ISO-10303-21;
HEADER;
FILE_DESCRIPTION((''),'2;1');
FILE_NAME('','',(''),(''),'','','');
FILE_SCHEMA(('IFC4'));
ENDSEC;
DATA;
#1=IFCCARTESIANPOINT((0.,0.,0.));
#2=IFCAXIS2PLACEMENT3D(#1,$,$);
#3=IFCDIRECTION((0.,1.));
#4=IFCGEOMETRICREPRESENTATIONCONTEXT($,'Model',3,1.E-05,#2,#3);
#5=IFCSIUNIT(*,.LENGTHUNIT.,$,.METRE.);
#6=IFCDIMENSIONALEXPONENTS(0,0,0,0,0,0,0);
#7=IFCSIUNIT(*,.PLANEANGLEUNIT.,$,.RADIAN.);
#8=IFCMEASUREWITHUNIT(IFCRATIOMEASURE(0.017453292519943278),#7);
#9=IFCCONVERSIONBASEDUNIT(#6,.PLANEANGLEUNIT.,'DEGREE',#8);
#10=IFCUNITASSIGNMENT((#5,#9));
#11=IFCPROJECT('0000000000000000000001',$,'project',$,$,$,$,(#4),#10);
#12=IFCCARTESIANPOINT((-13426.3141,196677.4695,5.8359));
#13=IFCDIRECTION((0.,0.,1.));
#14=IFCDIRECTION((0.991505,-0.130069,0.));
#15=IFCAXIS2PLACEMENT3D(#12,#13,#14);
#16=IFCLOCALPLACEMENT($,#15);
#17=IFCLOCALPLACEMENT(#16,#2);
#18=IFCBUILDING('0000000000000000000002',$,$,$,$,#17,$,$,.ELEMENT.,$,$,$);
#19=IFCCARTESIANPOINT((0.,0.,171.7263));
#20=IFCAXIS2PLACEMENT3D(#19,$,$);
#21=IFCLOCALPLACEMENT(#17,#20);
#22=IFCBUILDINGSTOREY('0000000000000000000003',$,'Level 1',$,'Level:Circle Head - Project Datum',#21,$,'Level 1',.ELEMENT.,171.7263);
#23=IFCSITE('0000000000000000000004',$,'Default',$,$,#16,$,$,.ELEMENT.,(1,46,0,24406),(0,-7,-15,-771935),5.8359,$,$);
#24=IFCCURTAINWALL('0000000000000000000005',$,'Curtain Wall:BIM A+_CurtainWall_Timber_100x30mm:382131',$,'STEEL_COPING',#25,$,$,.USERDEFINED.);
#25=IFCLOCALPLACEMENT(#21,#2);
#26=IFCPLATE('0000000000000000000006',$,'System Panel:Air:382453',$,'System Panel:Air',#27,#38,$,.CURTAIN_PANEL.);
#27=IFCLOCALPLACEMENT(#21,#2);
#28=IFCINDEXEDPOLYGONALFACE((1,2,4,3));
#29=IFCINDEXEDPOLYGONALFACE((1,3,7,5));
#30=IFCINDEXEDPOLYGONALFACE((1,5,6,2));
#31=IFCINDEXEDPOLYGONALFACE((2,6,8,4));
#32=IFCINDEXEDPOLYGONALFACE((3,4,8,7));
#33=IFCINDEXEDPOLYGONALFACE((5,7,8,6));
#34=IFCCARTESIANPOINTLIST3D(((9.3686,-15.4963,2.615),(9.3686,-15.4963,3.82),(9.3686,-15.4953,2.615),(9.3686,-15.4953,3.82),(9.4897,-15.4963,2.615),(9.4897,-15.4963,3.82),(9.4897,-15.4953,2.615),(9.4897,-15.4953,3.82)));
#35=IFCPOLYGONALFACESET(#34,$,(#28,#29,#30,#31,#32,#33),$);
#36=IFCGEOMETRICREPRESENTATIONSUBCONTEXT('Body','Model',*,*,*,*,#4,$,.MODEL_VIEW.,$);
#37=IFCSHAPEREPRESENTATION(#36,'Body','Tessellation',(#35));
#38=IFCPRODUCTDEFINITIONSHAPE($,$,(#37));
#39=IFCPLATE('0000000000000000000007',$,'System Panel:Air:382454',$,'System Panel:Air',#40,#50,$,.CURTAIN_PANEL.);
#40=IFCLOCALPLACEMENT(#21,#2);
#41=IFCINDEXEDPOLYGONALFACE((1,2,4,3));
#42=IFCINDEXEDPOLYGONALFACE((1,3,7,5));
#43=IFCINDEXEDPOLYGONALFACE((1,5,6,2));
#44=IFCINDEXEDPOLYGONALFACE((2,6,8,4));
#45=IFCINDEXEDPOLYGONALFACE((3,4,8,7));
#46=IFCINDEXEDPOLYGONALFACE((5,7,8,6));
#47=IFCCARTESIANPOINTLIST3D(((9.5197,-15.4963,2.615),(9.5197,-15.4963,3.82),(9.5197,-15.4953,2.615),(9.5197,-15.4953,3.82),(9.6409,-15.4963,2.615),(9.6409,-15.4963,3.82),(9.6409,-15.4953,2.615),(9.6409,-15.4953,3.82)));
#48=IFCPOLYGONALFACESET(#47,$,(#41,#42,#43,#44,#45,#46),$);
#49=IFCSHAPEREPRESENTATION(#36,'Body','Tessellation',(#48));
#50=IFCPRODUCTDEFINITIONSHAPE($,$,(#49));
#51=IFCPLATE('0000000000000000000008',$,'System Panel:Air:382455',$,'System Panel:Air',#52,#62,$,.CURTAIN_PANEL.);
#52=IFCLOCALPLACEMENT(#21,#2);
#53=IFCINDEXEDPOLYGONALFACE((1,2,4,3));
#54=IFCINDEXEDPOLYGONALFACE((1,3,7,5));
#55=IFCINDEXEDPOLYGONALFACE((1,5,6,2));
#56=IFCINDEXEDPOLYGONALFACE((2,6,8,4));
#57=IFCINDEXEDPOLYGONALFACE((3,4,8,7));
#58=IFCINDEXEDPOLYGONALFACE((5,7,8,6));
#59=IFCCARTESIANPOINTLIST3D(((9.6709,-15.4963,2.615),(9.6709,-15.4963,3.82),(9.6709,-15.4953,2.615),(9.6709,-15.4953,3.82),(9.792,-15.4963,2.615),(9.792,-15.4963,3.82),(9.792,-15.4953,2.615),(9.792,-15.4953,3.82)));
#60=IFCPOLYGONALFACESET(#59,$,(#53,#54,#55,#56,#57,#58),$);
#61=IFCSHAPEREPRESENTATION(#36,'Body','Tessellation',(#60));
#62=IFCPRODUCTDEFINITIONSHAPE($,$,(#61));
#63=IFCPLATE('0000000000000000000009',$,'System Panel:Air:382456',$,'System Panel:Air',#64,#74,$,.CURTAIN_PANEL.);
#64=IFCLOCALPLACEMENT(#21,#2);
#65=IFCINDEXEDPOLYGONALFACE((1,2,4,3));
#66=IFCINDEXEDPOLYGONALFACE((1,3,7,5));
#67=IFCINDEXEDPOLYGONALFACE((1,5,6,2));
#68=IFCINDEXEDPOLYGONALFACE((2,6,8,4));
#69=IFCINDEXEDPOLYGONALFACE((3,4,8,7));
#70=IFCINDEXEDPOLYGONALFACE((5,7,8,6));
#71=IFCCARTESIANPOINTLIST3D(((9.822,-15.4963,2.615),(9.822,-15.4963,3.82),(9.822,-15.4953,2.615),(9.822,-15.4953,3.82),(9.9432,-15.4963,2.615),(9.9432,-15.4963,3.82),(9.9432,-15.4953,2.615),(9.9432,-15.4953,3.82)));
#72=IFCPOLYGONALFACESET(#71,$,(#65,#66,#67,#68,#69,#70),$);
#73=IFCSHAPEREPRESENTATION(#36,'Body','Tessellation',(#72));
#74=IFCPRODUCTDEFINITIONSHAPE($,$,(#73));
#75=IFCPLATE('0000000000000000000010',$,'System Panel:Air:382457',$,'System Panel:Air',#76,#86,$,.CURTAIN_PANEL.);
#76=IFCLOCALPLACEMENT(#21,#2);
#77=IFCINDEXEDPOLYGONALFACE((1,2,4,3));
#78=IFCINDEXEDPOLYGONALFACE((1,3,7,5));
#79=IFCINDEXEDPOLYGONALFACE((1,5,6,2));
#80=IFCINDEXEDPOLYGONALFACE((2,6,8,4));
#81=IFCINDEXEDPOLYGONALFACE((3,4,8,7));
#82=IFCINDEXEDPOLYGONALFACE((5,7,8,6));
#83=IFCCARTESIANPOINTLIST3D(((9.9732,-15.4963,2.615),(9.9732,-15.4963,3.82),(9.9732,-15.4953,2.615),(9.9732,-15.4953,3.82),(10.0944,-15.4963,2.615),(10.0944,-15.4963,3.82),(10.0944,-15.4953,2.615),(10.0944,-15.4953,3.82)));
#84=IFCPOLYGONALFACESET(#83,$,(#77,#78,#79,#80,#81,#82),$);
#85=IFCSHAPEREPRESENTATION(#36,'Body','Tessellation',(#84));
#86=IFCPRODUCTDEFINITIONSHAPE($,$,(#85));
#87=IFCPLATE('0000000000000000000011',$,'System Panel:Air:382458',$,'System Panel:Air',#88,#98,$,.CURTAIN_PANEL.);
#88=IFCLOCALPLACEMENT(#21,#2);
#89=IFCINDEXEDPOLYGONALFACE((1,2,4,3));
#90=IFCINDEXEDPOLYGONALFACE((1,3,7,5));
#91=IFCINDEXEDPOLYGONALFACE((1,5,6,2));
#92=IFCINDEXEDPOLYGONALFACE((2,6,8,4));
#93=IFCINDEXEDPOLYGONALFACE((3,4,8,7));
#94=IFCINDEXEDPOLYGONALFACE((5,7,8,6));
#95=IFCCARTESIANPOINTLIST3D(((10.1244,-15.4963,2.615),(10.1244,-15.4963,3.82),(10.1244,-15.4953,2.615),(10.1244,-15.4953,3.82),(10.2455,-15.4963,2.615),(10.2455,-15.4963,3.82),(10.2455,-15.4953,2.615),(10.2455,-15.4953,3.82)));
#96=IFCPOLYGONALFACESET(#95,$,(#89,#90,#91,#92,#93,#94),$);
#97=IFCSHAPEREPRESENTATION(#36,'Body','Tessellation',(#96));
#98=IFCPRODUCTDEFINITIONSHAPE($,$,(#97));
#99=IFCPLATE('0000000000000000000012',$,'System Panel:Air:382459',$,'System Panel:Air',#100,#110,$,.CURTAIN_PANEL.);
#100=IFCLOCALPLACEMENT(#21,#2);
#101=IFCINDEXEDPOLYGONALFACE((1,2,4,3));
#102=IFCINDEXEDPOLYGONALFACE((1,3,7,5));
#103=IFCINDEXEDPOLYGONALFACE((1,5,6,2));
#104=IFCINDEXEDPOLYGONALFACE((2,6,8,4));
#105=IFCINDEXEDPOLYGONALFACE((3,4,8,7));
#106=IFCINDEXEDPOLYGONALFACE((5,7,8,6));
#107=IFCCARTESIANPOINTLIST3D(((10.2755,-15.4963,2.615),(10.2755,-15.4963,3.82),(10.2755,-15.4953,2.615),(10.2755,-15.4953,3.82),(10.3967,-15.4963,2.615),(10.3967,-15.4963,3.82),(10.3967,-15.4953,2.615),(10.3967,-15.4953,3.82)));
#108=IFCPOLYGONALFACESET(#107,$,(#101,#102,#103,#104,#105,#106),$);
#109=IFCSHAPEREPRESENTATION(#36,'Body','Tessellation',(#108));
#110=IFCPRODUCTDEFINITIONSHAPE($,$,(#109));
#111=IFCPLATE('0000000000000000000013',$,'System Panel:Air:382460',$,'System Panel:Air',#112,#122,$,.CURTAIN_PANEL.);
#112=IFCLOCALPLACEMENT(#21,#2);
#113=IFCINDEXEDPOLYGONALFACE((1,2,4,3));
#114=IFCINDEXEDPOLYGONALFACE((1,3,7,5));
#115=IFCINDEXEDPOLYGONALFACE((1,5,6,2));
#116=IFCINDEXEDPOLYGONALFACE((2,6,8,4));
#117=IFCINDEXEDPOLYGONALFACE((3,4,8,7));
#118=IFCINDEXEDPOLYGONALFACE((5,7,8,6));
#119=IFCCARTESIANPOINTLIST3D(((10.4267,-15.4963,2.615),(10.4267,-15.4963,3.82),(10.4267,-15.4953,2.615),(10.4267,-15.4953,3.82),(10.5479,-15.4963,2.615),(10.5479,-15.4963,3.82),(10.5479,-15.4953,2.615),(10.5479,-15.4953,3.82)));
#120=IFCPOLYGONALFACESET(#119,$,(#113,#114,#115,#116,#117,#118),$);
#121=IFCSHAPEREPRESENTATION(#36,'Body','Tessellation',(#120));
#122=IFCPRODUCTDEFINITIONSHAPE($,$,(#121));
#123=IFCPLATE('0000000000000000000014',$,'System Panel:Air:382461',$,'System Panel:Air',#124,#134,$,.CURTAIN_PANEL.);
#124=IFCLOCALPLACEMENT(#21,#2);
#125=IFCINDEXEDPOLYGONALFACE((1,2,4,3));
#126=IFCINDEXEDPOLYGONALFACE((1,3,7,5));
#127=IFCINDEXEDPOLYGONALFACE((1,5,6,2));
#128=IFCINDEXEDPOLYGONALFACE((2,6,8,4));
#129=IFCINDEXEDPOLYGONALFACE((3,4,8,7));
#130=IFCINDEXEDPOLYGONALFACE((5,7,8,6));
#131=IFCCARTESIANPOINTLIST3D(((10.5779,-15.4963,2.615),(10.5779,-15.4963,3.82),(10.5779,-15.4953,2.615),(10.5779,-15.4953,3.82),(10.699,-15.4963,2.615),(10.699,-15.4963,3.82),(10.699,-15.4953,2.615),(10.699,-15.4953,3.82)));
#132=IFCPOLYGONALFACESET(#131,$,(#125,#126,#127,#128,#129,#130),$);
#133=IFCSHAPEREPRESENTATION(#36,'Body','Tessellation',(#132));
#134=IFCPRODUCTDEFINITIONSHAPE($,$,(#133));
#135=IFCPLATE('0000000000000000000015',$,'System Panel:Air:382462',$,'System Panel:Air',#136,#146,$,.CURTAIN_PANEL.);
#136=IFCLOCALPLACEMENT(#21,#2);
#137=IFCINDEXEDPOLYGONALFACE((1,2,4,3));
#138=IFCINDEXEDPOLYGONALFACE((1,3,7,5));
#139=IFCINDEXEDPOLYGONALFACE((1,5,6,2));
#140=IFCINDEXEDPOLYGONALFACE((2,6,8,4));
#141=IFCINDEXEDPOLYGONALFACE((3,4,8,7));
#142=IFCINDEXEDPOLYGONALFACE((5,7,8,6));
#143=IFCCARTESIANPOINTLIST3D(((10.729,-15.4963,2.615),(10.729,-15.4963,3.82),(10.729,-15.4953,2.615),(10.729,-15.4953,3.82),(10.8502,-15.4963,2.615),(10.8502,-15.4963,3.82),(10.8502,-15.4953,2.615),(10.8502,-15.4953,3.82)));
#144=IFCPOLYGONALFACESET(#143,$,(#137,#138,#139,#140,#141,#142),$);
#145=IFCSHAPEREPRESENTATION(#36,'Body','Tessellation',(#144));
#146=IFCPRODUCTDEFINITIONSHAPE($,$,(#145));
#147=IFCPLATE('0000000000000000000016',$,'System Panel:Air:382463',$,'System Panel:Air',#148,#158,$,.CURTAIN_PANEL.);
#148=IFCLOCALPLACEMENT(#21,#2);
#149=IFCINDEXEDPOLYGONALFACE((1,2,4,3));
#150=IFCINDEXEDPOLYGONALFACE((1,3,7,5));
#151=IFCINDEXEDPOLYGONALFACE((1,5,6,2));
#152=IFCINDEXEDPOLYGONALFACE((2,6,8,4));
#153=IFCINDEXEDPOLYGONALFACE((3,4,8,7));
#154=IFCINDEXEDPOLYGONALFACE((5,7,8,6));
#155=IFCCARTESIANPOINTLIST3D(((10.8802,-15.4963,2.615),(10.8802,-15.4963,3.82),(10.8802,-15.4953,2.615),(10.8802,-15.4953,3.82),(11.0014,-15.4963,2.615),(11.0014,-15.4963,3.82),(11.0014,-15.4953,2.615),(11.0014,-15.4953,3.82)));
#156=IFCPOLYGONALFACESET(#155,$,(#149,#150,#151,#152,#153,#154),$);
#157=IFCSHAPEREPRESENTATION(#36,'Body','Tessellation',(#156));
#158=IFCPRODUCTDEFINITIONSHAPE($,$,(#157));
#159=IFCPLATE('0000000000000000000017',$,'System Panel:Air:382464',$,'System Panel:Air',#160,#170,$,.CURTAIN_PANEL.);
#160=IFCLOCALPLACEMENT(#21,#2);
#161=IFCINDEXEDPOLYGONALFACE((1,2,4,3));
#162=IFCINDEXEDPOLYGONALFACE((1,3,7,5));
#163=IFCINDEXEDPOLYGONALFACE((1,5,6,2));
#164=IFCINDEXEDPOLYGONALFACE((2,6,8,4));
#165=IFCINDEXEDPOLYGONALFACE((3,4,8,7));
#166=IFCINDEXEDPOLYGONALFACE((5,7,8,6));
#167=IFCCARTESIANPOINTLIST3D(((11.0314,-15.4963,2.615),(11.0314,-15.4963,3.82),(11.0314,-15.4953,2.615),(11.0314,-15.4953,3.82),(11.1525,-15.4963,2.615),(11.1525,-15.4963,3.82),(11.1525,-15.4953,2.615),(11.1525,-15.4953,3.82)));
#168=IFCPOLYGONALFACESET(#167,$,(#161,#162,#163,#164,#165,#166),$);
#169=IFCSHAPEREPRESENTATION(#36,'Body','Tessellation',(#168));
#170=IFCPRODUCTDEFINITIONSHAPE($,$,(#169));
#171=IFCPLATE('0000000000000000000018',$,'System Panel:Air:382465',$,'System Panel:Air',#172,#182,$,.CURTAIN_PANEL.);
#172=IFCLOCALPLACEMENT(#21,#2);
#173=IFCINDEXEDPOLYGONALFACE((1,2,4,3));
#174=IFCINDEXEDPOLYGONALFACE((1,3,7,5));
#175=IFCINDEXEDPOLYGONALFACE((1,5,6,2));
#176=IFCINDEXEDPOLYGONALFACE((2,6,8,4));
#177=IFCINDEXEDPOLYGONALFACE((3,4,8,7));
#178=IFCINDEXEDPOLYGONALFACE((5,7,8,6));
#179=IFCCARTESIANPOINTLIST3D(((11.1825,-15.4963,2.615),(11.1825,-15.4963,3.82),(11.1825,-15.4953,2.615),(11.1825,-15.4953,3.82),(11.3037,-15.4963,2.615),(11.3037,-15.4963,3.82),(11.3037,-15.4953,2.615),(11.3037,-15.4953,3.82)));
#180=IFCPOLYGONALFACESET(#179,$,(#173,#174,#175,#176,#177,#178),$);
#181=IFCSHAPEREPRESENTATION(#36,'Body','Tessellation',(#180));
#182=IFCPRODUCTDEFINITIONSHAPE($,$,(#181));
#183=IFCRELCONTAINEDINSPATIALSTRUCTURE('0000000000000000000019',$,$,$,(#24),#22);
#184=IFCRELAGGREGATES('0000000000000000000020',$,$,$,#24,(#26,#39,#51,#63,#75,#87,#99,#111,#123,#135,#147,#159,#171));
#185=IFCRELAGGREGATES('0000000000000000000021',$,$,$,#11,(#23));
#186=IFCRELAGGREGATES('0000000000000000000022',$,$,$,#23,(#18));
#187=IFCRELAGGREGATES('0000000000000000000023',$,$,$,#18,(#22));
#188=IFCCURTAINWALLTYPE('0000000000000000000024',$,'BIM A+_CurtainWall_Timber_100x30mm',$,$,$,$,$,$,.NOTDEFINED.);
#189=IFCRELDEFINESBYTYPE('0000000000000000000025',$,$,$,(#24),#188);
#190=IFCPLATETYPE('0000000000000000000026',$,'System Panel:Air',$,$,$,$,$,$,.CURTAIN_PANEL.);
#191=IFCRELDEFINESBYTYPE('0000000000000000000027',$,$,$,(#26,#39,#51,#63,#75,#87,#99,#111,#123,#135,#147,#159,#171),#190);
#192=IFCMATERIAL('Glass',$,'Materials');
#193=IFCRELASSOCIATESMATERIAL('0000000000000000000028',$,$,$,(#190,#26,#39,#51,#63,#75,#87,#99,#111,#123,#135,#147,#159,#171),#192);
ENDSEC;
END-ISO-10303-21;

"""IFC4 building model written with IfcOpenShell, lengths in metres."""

from ifc_helpers import new_model, entity, si_unit, converted_unit, direction, frame, origin, place, context, subcontext, project, spatial, indexed_curve, outline, extrude, source, transform, mapped, material, type_object, type_shapes, element, aggregate, save


model = new_model("IFC4")

# Units and contexts
model_context = context("Model", 3, precision=1e-05, world=origin(), true_north=direction((0.0, 1.0)))
body_context = subcontext(model_context, "Body", "Model", "MODEL_VIEW")
ifc_project = project(units=[si_unit("LENGTHUNIT", "METRE"), converted_unit("PLANEANGLEUNIT", "DEGREE", entity("IfcRatioMeasure", 0.017453292519943278), si_unit("PLANEANGLEUNIT", "RADIAN"), dimensions=[0, 0, 0, 0, 0, 0, 0])], contexts=[model_context])

# Site, building, storey
site_placement = place(None, frame((-13426.3141, 196677.4695, 5.8359), z_axis=(0.0, 0.0, 1.0), x_axis=(0.991505, -0.130069, 0.0)))
site = spatial("IfcSite", under=ifc_project, at=site_placement, Name="Default", CompositionType="ELEMENT", RefLatitude=(1, 46, 0, 24406), RefLongitude=(0, -7, -15, -771935), RefElevation=5.8359)
building_placement = place(site_placement, origin())
building = spatial("IfcBuilding", under=site, at=building_placement, CompositionType="ELEMENT")
storey_placement = place(building_placement, frame((0.0, 0.0, 171.7263)))
storey = spatial("IfcBuildingStorey", under=building, at=storey_placement, Name="Level 1", ObjectType="Level:Circle Head - Project Datum", LongName="Level 1", CompositionType="ELEMENT", Elevation=171.7263)

# Curtain wall, plates
curtain_wall_type = type_object("IfcCurtainWallType", Name="BIM A+_CurtainWall_Timber_100x30mm", PredefinedType="NOTDEFINED")
curtain_wall_placement = place(storey_placement, frame((0.0, 0.0, -171.7263)))
curtain_wall = element("IfcCurtainWall", 1, at=curtain_wall_placement, inside=storey, type_object=curtain_wall_type, Name="Curtain Wall:BIM A+_CurtainWall_Timber_100x30mm:382131", ObjectType="STEEL_COPING", PredefinedType="USERDEFINED")
ifc_material_1 = material(Name="Glass", Category="Materials")
plate_type = type_object("IfcPlateType", Name="System Panel:Air", PredefinedType="CURTAIN_PANEL", material=ifc_material_1)
shared_shape_1 = source(origin(), body_context, "Body", "SweptSolid", [
    extrude(outline(indexed_curve([(-0.0005, -0.0606), (0.0005, -0.0606), (0.0005, 0.0606), (-0.0005, 0.0606), (-0.0005, -0.0606)], self_intersect=False)), frame((0.0, 0.0, 0.0), z_axis=(0.0, 0.0, 1.0), x_axis=(0.0, 1.0, 0.0)), (0.0, 0.0, 1.0), 1.205),
])
type_shapes(plate_type, [shared_shape_1])
plate_1_placement = place(curtain_wall_placement, frame((9.4291, -15.4958, 174.3413)))
plate_1 = element("IfcPlate", 2, at=plate_1_placement, type_object=plate_type, material=ifc_material_1, Name="System Panel:Air:382453", ObjectType="System Panel:Air", PredefinedType="CURTAIN_PANEL", context=body_context, shape_type="MappedRepresentation", body=[
    mapped(shared_shape_1, transform((0.0, 0.0, 0.0), scale=1.0)),
])
plate_2_placement = place(curtain_wall_placement, frame((9.5803, -15.4958, 174.3413)))
plate_2 = element("IfcPlate", 3, at=plate_2_placement, type_object=plate_type, material=ifc_material_1, Name="System Panel:Air:382454", ObjectType="System Panel:Air", PredefinedType="CURTAIN_PANEL", context=body_context, shape_type="MappedRepresentation", body=[
    mapped(shared_shape_1, transform((0.0, 0.0, 0.0), scale=1.0)),
])
plate_3_placement = place(curtain_wall_placement, frame((9.7315, -15.4958, 174.3413)))
plate_3 = element("IfcPlate", 4, at=plate_3_placement, type_object=plate_type, material=ifc_material_1, Name="System Panel:Air:382455", ObjectType="System Panel:Air", PredefinedType="CURTAIN_PANEL", context=body_context, shape_type="MappedRepresentation", body=[
    mapped(shared_shape_1, transform((0.0, 0.0, 0.0), scale=1.0)),
])
plate_4_placement = place(curtain_wall_placement, frame((9.8826, -15.4958, 174.3413)))
plate_4 = element("IfcPlate", 5, at=plate_4_placement, type_object=plate_type, material=ifc_material_1, Name="System Panel:Air:382456", ObjectType="System Panel:Air", PredefinedType="CURTAIN_PANEL", context=body_context, shape_type="MappedRepresentation", body=[
    mapped(shared_shape_1, transform((0.0, 0.0, 0.0), scale=1.0)),
])
plate_5_placement = place(curtain_wall_placement, frame((10.0338, -15.4958, 174.3413)))
plate_5 = element("IfcPlate", 6, at=plate_5_placement, type_object=plate_type, material=ifc_material_1, Name="System Panel:Air:382457", ObjectType="System Panel:Air", PredefinedType="CURTAIN_PANEL", context=body_context, shape_type="MappedRepresentation", body=[
    mapped(shared_shape_1, transform((0.0, 0.0, 0.0), scale=1.0)),
])
plate_6_placement = place(curtain_wall_placement, frame((10.185, -15.4958, 174.3413)))
plate_6 = element("IfcPlate", 7, at=plate_6_placement, type_object=plate_type, material=ifc_material_1, Name="System Panel:Air:382458", ObjectType="System Panel:Air", PredefinedType="CURTAIN_PANEL", context=body_context, shape_type="MappedRepresentation", body=[
    mapped(shared_shape_1, transform((0.0, 0.0, 0.0), scale=1.0)),
])
plate_7_placement = place(curtain_wall_placement, frame((10.3361, -15.4958, 174.3413)))
plate_7 = element("IfcPlate", 8, at=plate_7_placement, type_object=plate_type, material=ifc_material_1, Name="System Panel:Air:382459", ObjectType="System Panel:Air", PredefinedType="CURTAIN_PANEL", context=body_context, shape_type="MappedRepresentation", body=[
    mapped(shared_shape_1, transform((0.0, 0.0, 0.0), scale=1.0)),
])
plate_8_placement = place(curtain_wall_placement, frame((10.4873, -15.4958, 174.3413)))
plate_8 = element("IfcPlate", 9, at=plate_8_placement, type_object=plate_type, material=ifc_material_1, Name="System Panel:Air:382460", ObjectType="System Panel:Air", PredefinedType="CURTAIN_PANEL", context=body_context, shape_type="MappedRepresentation", body=[
    mapped(shared_shape_1, transform((0.0, 0.0, 0.0), scale=1.0)),
])
plate_9_placement = place(curtain_wall_placement, frame((10.6384, -15.4958, 174.3413)))
plate_9 = element("IfcPlate", 10, at=plate_9_placement, type_object=plate_type, material=ifc_material_1, Name="System Panel:Air:382461", ObjectType="System Panel:Air", PredefinedType="CURTAIN_PANEL", context=body_context, shape_type="MappedRepresentation", body=[
    mapped(shared_shape_1, transform((0.0, 0.0, 0.0), scale=1.0)),
])
plate_10_placement = place(curtain_wall_placement, frame((10.7896, -15.4958, 174.3413)))
plate_10 = element("IfcPlate", 11, at=plate_10_placement, type_object=plate_type, material=ifc_material_1, Name="System Panel:Air:382462", ObjectType="System Panel:Air", PredefinedType="CURTAIN_PANEL", context=body_context, shape_type="MappedRepresentation", body=[
    mapped(shared_shape_1, transform((0.0, 0.0, 0.0), scale=1.0)),
])
plate_11_placement = place(curtain_wall_placement, frame((10.9408, -15.4958, 174.3413)))
plate_11 = element("IfcPlate", 12, at=plate_11_placement, type_object=plate_type, material=ifc_material_1, Name="System Panel:Air:382463", ObjectType="System Panel:Air", PredefinedType="CURTAIN_PANEL", context=body_context, shape_type="MappedRepresentation", body=[
    mapped(shared_shape_1, transform((0.0, 0.0, 0.0), scale=1.0)),
])
plate_12_placement = place(curtain_wall_placement, frame((11.0919, -15.4958, 174.3413)))
plate_12 = element("IfcPlate", 13, at=plate_12_placement, type_object=plate_type, material=ifc_material_1, Name="System Panel:Air:382464", ObjectType="System Panel:Air", PredefinedType="CURTAIN_PANEL", context=body_context, shape_type="MappedRepresentation", body=[
    mapped(shared_shape_1, transform((0.0, 0.0, 0.0), scale=1.0)),
])
plate_13_placement = place(curtain_wall_placement, frame((11.2431, -15.4958, 174.3413)))
plate_13 = element("IfcPlate", 14, at=plate_13_placement, type_object=plate_type, material=ifc_material_1, Name="System Panel:Air:382465", ObjectType="System Panel:Air", PredefinedType="CURTAIN_PANEL", context=body_context, shape_type="MappedRepresentation", body=[
    mapped(shared_shape_1, transform((0.0, 0.0, 0.0), scale=1.0)),
])
aggregate(curtain_wall, [plate_1, plate_2, plate_3, plate_4, plate_5, plate_6, plate_7, plate_8, plate_9, plate_10, plate_11, plate_12, plate_13])

save(model, "model.ifc")
